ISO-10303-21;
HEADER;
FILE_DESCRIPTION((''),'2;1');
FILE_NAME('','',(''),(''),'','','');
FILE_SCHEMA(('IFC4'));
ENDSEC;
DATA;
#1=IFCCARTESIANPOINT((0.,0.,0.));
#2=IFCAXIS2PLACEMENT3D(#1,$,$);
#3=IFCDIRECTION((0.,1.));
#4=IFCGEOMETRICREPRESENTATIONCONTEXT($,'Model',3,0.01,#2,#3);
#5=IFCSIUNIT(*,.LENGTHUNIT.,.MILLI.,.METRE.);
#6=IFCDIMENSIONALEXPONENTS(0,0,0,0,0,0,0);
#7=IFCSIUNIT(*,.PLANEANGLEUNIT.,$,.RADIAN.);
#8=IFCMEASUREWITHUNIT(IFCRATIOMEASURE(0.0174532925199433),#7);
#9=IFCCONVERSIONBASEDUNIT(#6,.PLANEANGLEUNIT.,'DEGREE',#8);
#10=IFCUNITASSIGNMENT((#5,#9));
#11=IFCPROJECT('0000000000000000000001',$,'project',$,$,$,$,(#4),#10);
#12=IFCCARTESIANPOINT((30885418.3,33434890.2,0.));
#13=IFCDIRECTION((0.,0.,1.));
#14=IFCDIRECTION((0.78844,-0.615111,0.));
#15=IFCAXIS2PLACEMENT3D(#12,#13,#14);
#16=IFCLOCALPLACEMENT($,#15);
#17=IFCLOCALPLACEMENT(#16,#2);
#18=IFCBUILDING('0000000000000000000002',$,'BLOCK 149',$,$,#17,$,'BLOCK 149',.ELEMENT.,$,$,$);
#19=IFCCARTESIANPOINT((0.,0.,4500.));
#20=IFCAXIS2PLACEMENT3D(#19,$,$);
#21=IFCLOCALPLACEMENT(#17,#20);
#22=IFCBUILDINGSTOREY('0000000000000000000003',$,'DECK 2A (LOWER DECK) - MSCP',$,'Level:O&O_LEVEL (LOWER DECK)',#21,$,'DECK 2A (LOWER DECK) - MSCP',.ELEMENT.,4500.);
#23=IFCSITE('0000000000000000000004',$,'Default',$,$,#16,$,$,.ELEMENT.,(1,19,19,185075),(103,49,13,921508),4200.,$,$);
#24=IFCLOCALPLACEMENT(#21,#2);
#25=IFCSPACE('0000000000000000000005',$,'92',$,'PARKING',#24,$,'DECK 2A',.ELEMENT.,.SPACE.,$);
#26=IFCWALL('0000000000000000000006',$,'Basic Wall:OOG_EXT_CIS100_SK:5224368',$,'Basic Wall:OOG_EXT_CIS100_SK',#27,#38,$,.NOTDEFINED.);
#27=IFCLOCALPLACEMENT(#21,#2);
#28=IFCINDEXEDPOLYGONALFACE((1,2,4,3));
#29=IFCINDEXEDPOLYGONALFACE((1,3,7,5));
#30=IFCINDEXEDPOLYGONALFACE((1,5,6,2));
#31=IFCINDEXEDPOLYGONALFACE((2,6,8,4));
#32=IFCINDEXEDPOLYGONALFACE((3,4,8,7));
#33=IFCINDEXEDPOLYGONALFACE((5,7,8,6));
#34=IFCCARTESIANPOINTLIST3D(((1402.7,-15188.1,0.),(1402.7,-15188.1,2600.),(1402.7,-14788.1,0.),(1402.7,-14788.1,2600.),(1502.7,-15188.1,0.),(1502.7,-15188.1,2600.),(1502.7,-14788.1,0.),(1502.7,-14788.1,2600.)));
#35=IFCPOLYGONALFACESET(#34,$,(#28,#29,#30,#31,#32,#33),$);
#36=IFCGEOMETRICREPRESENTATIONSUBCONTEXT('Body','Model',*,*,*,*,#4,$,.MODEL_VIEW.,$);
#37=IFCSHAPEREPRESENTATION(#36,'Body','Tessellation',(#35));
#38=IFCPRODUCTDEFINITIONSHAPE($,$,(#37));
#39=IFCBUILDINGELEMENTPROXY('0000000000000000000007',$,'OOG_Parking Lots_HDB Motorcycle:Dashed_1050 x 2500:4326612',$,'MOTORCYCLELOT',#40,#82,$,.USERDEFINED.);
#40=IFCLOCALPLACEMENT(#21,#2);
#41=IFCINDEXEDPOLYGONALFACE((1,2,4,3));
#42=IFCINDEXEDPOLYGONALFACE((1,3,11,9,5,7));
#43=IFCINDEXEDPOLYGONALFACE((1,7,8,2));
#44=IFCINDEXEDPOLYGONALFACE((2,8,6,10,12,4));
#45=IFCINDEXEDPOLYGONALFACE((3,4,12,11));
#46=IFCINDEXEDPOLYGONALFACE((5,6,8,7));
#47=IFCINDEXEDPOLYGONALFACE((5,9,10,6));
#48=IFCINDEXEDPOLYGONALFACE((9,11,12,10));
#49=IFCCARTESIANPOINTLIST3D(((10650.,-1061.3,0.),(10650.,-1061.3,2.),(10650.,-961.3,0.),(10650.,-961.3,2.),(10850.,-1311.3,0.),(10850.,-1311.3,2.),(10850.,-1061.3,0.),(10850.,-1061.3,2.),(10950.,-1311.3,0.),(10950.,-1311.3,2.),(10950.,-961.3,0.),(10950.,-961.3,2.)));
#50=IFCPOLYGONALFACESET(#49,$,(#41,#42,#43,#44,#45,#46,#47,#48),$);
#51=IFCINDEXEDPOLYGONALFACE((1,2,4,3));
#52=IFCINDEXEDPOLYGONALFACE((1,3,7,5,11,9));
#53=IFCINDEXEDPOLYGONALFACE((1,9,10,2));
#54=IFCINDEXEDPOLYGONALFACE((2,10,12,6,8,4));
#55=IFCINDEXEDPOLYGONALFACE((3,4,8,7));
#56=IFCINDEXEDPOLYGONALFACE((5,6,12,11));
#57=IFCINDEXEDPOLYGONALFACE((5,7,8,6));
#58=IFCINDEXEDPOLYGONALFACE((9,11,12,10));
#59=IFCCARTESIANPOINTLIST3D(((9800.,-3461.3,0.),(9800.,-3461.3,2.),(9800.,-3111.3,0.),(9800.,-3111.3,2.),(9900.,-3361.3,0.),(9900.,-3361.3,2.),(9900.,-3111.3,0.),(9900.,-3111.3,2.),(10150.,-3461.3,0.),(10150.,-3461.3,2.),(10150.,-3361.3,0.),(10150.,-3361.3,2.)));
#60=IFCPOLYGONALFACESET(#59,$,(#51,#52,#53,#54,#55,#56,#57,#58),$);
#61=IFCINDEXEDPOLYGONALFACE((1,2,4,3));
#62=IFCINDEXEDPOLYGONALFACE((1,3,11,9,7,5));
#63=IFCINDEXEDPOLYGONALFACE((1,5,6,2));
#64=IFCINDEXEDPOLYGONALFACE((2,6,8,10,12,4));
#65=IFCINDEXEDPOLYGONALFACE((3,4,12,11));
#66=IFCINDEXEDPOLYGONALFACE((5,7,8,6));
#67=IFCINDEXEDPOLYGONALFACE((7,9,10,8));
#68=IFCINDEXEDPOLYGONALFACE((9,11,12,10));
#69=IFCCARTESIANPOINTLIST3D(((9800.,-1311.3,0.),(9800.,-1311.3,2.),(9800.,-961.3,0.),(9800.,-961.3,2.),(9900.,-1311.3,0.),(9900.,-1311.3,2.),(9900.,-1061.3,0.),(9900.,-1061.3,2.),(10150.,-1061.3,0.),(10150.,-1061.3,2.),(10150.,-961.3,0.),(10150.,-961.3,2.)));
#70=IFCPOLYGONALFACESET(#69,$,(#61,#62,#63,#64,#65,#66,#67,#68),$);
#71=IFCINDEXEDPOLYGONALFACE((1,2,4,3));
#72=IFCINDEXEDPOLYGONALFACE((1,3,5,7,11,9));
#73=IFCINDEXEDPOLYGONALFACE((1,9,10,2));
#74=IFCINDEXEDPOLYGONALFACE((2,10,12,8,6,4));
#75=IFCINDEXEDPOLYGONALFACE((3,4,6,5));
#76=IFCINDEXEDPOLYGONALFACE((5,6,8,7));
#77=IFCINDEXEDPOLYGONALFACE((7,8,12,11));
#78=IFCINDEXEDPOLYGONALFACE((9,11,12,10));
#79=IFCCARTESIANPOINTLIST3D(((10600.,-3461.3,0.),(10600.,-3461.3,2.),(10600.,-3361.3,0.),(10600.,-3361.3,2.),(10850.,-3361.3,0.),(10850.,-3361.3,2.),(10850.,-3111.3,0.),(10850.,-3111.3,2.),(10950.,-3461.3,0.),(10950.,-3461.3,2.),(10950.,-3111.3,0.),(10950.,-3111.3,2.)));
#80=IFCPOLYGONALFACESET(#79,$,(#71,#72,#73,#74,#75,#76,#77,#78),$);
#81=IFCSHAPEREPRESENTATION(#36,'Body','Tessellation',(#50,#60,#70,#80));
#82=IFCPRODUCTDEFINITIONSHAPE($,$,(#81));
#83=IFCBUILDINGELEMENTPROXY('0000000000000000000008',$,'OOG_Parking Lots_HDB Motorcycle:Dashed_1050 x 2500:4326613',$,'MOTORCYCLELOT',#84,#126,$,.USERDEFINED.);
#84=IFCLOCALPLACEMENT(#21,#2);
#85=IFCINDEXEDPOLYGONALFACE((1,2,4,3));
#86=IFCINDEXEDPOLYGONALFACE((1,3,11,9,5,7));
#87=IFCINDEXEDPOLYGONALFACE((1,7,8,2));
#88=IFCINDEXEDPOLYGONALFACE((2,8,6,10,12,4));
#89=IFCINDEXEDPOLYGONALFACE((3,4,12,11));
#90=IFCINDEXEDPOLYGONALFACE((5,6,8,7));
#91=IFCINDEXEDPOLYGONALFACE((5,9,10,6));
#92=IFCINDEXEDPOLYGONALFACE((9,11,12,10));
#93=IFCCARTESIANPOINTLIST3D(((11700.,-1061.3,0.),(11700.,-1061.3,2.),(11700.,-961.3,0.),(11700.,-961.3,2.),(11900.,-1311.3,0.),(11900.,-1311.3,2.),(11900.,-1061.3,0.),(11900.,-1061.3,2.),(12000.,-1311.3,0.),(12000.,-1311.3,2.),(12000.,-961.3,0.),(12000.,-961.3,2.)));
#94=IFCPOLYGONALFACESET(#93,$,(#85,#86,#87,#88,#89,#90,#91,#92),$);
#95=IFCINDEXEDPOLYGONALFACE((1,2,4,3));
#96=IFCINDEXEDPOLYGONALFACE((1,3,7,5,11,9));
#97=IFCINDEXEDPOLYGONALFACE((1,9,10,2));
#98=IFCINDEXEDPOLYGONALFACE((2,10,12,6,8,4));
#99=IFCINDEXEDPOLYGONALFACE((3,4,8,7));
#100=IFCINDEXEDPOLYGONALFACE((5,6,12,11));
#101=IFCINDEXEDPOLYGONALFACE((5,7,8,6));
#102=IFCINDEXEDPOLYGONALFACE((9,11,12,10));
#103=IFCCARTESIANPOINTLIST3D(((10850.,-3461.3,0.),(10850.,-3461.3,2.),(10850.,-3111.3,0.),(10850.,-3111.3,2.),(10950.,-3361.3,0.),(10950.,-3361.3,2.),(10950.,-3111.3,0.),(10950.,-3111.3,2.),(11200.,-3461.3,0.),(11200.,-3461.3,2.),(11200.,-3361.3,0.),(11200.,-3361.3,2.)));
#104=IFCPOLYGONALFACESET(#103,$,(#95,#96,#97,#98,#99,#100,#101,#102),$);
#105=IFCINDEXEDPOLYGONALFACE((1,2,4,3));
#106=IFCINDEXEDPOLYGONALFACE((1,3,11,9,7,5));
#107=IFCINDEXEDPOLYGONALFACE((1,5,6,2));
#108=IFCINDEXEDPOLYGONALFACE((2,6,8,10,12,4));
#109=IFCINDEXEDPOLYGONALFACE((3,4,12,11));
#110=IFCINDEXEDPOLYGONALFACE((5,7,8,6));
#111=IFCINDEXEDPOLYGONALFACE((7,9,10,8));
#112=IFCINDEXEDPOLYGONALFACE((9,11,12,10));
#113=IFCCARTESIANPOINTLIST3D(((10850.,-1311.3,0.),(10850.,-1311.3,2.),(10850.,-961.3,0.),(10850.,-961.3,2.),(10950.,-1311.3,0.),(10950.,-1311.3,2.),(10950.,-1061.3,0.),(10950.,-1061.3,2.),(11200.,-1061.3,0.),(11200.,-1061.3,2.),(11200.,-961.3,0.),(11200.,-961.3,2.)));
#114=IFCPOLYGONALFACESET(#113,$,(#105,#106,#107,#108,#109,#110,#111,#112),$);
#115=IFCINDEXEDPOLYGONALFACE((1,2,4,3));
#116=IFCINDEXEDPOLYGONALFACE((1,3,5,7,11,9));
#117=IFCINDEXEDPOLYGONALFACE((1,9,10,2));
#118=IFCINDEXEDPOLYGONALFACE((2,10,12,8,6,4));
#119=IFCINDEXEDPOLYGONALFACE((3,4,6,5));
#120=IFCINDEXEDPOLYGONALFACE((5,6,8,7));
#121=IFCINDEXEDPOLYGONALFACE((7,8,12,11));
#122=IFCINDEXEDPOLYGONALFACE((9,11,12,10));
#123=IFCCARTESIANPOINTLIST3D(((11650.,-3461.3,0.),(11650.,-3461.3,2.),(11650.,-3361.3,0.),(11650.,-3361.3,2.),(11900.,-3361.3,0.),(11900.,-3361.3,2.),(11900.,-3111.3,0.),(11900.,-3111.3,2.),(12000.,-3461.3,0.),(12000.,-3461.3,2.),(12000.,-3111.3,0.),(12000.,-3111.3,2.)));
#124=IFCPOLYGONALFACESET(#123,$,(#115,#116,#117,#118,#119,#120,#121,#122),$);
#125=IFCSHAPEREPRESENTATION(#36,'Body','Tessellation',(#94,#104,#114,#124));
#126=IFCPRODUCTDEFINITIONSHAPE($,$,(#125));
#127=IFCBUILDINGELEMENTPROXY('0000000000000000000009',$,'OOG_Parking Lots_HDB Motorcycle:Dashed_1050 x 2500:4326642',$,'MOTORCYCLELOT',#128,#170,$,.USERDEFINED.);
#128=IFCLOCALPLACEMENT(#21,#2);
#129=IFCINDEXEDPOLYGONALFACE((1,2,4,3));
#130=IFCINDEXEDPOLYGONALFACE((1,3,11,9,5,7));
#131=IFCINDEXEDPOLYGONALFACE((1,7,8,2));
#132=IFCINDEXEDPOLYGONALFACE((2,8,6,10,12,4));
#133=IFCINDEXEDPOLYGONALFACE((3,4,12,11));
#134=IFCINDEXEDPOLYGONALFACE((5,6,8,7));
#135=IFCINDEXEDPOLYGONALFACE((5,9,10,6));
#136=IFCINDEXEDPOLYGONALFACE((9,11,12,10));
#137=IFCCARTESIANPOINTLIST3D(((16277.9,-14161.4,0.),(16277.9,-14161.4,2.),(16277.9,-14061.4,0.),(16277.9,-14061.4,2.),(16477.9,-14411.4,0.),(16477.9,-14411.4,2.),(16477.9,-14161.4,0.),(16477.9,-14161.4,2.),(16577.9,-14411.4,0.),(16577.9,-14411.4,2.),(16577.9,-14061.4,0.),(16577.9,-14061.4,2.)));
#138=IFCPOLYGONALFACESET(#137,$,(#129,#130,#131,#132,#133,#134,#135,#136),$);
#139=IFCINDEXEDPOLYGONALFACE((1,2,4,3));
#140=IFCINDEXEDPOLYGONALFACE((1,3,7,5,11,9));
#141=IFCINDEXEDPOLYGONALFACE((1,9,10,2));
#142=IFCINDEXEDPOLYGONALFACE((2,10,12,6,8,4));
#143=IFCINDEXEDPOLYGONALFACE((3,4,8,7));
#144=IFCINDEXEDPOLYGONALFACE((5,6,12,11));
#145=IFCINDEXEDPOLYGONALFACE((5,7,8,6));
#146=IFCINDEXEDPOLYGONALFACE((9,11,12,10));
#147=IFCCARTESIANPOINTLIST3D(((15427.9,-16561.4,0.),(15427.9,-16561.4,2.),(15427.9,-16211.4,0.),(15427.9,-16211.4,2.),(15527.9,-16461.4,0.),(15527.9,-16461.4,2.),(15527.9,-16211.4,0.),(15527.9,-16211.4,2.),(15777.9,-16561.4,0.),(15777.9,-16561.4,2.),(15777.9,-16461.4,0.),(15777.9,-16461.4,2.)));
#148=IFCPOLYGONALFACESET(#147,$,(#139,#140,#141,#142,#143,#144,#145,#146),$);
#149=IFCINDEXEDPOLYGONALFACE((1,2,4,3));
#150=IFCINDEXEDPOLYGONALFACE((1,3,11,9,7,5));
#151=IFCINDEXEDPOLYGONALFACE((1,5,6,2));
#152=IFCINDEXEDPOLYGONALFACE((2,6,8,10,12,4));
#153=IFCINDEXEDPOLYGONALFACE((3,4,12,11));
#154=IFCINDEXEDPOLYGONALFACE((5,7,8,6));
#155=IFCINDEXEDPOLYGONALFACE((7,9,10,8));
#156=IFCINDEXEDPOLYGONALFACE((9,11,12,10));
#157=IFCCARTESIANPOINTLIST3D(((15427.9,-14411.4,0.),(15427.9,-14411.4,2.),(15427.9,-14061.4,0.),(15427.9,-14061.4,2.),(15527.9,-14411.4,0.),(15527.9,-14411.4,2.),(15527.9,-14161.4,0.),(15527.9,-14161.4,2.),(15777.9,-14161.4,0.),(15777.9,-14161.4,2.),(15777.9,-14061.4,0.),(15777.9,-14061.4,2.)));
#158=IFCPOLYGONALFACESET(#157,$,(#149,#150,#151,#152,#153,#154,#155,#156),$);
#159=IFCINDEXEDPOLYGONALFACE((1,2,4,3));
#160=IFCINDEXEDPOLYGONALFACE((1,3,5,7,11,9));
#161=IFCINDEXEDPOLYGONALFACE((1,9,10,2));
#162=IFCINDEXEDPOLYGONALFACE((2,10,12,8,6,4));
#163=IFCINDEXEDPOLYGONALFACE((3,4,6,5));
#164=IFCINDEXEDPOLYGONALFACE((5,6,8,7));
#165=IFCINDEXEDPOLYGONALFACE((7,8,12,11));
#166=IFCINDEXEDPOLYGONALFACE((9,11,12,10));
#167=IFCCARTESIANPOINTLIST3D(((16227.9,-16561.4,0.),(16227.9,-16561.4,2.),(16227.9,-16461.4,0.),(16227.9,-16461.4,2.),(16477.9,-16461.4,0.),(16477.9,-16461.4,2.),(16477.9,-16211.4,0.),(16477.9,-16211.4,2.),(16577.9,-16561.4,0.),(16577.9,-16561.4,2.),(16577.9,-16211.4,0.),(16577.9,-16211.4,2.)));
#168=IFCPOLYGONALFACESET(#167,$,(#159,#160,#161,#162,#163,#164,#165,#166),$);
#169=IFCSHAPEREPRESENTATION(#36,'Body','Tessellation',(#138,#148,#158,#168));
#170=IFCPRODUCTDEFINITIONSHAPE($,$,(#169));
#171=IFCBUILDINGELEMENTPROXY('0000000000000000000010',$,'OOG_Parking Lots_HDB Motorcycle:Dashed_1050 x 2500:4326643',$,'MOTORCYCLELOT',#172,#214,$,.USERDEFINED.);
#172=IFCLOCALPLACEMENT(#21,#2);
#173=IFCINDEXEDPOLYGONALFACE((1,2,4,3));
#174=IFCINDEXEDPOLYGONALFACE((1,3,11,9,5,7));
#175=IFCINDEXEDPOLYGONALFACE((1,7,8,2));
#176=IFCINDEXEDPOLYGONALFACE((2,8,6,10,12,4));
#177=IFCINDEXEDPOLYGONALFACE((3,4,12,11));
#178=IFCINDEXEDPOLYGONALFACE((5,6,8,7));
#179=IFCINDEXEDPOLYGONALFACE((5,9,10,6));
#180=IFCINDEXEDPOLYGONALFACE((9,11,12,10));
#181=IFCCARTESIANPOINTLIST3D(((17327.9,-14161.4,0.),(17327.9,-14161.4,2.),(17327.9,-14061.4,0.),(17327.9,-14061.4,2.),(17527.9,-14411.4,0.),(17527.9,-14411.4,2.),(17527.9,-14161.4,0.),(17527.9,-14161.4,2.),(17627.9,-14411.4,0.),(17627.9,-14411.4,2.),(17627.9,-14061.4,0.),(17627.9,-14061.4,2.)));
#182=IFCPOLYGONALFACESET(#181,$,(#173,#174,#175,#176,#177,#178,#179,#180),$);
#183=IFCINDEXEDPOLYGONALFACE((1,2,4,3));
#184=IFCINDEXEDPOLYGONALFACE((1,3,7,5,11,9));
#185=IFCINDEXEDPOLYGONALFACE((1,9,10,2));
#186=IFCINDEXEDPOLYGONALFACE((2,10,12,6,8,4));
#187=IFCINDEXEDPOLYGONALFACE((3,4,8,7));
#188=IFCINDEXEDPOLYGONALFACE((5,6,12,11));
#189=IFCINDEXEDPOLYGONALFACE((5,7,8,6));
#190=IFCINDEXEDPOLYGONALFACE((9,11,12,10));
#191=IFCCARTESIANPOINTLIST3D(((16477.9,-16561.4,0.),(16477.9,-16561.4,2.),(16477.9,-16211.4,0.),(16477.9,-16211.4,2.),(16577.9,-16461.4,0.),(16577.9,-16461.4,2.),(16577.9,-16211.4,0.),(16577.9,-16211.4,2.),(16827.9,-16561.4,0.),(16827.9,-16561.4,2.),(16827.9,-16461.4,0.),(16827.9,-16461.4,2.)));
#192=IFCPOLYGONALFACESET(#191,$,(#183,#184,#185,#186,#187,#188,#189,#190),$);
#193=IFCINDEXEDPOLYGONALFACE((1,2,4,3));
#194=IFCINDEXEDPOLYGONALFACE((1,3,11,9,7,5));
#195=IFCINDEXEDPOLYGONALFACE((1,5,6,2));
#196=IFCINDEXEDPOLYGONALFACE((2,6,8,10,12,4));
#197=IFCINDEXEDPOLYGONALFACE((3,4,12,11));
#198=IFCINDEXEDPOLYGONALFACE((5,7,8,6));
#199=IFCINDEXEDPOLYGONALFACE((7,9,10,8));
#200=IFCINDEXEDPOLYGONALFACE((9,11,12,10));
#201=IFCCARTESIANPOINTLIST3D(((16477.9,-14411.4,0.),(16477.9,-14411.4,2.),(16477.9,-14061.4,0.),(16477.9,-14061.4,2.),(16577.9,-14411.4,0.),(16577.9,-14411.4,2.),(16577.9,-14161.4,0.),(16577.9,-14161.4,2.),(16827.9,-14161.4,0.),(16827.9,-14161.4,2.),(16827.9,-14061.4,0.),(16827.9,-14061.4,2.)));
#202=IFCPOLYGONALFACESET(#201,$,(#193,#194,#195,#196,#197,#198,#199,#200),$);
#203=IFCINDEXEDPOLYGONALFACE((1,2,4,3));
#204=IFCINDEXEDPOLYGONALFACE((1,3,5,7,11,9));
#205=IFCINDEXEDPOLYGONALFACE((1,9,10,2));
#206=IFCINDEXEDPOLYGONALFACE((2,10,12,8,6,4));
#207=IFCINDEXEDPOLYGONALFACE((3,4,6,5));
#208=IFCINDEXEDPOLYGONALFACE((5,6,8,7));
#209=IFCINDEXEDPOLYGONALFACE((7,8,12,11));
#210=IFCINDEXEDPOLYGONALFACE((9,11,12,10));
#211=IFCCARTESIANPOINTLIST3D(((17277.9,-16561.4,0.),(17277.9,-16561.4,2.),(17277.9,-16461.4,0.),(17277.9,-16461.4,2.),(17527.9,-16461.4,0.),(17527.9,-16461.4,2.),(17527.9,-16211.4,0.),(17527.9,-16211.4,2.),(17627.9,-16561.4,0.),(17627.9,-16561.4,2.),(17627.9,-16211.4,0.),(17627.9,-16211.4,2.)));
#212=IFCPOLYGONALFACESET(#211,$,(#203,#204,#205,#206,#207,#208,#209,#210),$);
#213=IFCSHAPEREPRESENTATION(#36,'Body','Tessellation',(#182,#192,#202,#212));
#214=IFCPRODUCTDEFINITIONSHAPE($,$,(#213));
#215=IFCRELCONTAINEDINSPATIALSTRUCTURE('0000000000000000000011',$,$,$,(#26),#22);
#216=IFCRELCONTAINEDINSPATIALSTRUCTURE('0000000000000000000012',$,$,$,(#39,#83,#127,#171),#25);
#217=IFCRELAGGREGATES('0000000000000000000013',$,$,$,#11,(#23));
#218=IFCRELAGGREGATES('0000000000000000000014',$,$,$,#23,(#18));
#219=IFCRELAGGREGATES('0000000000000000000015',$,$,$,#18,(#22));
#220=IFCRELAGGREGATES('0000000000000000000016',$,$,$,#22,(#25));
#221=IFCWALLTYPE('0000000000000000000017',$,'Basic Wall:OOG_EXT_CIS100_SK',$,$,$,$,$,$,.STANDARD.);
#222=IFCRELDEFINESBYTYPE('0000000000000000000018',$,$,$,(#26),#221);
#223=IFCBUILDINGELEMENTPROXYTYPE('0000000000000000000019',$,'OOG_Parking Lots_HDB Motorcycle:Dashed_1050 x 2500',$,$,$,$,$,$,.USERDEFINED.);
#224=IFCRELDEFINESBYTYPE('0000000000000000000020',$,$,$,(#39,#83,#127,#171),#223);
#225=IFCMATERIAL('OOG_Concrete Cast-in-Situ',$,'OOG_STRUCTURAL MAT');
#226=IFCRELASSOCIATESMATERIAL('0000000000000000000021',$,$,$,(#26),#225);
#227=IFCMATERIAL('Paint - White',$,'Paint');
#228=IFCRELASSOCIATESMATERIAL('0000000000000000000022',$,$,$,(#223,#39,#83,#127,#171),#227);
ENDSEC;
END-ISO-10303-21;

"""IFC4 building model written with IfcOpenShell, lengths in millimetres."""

from ifc_helpers import new_model, entity, si_unit, converted_unit, direction, frame, origin, place, context, subcontext, project, spatial, indexed_curve, outline, extrude, source, transform, mapped, material, type_object, type_shapes, element, save


model = new_model("IFC4")

# Units and contexts
model_context = context("Model", 3, precision=0.01, world=origin(), true_north=direction((0.0, 1.0)))
body_context = subcontext(model_context, "Body", "Model", "MODEL_VIEW")
ifc_project = project(units=[si_unit("LENGTHUNIT", "METRE", prefix="MILLI"), converted_unit("PLANEANGLEUNIT", "DEGREE", entity("IfcRatioMeasure", 0.0174532925199433), si_unit("PLANEANGLEUNIT", "RADIAN"), dimensions=[0, 0, 0, 0, 0, 0, 0])], contexts=[model_context])

# Site, building, storey
site_placement = place(None, frame((30885418.3, 33434890.2, 0.0), z_axis=(0.0, 0.0, 1.0), x_axis=(0.78844, -0.615111, 0.0)))
site = spatial("IfcSite", under=ifc_project, at=site_placement, Name="Default", CompositionType="ELEMENT", RefLatitude=(1, 19, 19, 185075), RefLongitude=(103, 49, 13, 921508), RefElevation=4200.0)
building_placement = place(site_placement, origin())
building = spatial("IfcBuilding", under=site, at=building_placement, Name="BLOCK 149", LongName="BLOCK 149", CompositionType="ELEMENT")
storey_placement = place(building_placement, frame((0.0, 0.0, 4500.0)))
storey = spatial("IfcBuildingStorey", under=building, at=storey_placement, Name="DECK 2A (LOWER DECK) - MSCP", ObjectType="Level:O&O_LEVEL (LOWER DECK)", LongName="DECK 2A (LOWER DECK) - MSCP", CompositionType="ELEMENT", Elevation=4500.0)

# Wall
ifc_material_1 = material(Name="OOG_Concrete Cast-in-Situ", Category="OOG_STRUCTURAL MAT")
wall_type_1 = type_object("IfcWallType", Name="Basic Wall:OOG_EXT_CIS100_SK", PredefinedType="STANDARD")
wall_1_placement = place(storey_placement, frame((1452.7, -15188.1, 0.0), z_axis=(0.0, 0.0, 1.0), x_axis=(0.0, 1.0, 0.0)))
element("IfcWall", 1, at=wall_1_placement, inside=storey, type_object=wall_type_1, material=ifc_material_1, Name="Basic Wall:OOG_EXT_CIS100_SK:5224368", ObjectType="Basic Wall:OOG_EXT_CIS100_SK", PredefinedType="NOTDEFINED", context=body_context, shape_type="SweptSolid", body=[
    extrude(outline(indexed_curve([(400.0, 50.0), (0.0, 50.0), (0.0, -50.0), (400.0, -50.0), (400.0, 50.0)], self_intersect=False)), origin(), (0.0, 0.0, 1.0), 2600.0),
])

# Shared definitions
space_placement = place(storey_placement, origin())
space = spatial("IfcSpace", under=storey, at=space_placement, Name="92", ObjectType="PARKING", LongName="DECK 2A", CompositionType="ELEMENT", PredefinedType="SPACE")

# Building element proxies
ifc_material_2 = material(Name="Paint - White", Category="Paint")
building_element_proxy_type_1 = type_object("IfcBuildingElementProxyType", Name="OOG_Parking Lots_HDB Motorcycle:Dashed_1050 x 2500", PredefinedType="USERDEFINED", material=ifc_material_2)
shared_shape_1 = source(origin(), body_context, "Body", "SweptSolid", [
    extrude(outline(indexed_curve([(-200.0, -133.3), (150.0, -133.3), (150.0, 166.7), (50.0, 166.7), (50.0, -33.3), (-200.0, -33.3), (-200.0, -133.3)], self_intersect=False)), frame((966.7, -100.0, 0.0), z_axis=(0.0, 0.0, 1.0), x_axis=(0.0, 1.0, 0.0)), (0.0, 0.0, 1.0), 2.0),
    extrude(outline(indexed_curve([(-200.0, -150.0), (150.0, -150.0), (150.0, 200.0), (50.0, 200.0), (50.0, -50.0), (-200.0, -50.0), (-200.0, -150.0)], self_intersect=False)), frame((100.0, -2300.0, 0.0), z_axis=(0.0, 0.0, 1.0), x_axis=(0.0, -1.0, 0.0)), (0.0, 0.0, 1.0), 2.0),
    extrude(outline(indexed_curve([(-200.0, -150.0), (150.0, -150.0), (150.0, 200.0), (50.0, 200.0), (50.0, -50.0), (-200.0, -50.0), (-200.0, -150.0)], self_intersect=False)), frame((100.0, -100.0, 0.0), z_axis=(0.0, 0.0, 1.0), x_axis=(-1.0, 0.0, 0.0)), (0.0, 0.0, 1.0), 2.0),
    extrude(outline(indexed_curve([(-200.0, -150.0), (150.0, -150.0), (150.0, 200.0), (50.0, 200.0), (50.0, -50.0), (-200.0, -50.0), (-200.0, -150.0)], self_intersect=False)), frame((950.0, -2300.0, 0.0)), (0.0, 0.0, 1.0), 2.0),
])
type_shapes(building_element_proxy_type_1, [shared_shape_1])
for number, where, name in (
    (2, (9850.0, -1011.3, 0.0), "OOG_Parking Lots_HDB Motorcycle:Dashed_1050 x 2500:4326612"),
    (3, (10900.0, -1011.3, 0.0), "OOG_Parking Lots_HDB Motorcycle:Dashed_1050 x 2500:4326613"),
    (4, (15477.9, -14111.4, 0.0), "OOG_Parking Lots_HDB Motorcycle:Dashed_1050 x 2500:4326642"),
    (5, (16527.9, -14111.4, 0.0), "OOG_Parking Lots_HDB Motorcycle:Dashed_1050 x 2500:4326643"),
):
    element("IfcBuildingElementProxy", number, at=place(space_placement, frame(where)), inside=space, type_object=building_element_proxy_type_1, material=ifc_material_2, Name=name, ObjectType="MOTORCYCLELOT", PredefinedType="USERDEFINED", context=body_context, shape_type="MappedRepresentation", body=[
        mapped(shared_shape_1, transform((0.0, 0.0, 0.0), scale=1.0)),
    ])

save(model, "model.ifc")
